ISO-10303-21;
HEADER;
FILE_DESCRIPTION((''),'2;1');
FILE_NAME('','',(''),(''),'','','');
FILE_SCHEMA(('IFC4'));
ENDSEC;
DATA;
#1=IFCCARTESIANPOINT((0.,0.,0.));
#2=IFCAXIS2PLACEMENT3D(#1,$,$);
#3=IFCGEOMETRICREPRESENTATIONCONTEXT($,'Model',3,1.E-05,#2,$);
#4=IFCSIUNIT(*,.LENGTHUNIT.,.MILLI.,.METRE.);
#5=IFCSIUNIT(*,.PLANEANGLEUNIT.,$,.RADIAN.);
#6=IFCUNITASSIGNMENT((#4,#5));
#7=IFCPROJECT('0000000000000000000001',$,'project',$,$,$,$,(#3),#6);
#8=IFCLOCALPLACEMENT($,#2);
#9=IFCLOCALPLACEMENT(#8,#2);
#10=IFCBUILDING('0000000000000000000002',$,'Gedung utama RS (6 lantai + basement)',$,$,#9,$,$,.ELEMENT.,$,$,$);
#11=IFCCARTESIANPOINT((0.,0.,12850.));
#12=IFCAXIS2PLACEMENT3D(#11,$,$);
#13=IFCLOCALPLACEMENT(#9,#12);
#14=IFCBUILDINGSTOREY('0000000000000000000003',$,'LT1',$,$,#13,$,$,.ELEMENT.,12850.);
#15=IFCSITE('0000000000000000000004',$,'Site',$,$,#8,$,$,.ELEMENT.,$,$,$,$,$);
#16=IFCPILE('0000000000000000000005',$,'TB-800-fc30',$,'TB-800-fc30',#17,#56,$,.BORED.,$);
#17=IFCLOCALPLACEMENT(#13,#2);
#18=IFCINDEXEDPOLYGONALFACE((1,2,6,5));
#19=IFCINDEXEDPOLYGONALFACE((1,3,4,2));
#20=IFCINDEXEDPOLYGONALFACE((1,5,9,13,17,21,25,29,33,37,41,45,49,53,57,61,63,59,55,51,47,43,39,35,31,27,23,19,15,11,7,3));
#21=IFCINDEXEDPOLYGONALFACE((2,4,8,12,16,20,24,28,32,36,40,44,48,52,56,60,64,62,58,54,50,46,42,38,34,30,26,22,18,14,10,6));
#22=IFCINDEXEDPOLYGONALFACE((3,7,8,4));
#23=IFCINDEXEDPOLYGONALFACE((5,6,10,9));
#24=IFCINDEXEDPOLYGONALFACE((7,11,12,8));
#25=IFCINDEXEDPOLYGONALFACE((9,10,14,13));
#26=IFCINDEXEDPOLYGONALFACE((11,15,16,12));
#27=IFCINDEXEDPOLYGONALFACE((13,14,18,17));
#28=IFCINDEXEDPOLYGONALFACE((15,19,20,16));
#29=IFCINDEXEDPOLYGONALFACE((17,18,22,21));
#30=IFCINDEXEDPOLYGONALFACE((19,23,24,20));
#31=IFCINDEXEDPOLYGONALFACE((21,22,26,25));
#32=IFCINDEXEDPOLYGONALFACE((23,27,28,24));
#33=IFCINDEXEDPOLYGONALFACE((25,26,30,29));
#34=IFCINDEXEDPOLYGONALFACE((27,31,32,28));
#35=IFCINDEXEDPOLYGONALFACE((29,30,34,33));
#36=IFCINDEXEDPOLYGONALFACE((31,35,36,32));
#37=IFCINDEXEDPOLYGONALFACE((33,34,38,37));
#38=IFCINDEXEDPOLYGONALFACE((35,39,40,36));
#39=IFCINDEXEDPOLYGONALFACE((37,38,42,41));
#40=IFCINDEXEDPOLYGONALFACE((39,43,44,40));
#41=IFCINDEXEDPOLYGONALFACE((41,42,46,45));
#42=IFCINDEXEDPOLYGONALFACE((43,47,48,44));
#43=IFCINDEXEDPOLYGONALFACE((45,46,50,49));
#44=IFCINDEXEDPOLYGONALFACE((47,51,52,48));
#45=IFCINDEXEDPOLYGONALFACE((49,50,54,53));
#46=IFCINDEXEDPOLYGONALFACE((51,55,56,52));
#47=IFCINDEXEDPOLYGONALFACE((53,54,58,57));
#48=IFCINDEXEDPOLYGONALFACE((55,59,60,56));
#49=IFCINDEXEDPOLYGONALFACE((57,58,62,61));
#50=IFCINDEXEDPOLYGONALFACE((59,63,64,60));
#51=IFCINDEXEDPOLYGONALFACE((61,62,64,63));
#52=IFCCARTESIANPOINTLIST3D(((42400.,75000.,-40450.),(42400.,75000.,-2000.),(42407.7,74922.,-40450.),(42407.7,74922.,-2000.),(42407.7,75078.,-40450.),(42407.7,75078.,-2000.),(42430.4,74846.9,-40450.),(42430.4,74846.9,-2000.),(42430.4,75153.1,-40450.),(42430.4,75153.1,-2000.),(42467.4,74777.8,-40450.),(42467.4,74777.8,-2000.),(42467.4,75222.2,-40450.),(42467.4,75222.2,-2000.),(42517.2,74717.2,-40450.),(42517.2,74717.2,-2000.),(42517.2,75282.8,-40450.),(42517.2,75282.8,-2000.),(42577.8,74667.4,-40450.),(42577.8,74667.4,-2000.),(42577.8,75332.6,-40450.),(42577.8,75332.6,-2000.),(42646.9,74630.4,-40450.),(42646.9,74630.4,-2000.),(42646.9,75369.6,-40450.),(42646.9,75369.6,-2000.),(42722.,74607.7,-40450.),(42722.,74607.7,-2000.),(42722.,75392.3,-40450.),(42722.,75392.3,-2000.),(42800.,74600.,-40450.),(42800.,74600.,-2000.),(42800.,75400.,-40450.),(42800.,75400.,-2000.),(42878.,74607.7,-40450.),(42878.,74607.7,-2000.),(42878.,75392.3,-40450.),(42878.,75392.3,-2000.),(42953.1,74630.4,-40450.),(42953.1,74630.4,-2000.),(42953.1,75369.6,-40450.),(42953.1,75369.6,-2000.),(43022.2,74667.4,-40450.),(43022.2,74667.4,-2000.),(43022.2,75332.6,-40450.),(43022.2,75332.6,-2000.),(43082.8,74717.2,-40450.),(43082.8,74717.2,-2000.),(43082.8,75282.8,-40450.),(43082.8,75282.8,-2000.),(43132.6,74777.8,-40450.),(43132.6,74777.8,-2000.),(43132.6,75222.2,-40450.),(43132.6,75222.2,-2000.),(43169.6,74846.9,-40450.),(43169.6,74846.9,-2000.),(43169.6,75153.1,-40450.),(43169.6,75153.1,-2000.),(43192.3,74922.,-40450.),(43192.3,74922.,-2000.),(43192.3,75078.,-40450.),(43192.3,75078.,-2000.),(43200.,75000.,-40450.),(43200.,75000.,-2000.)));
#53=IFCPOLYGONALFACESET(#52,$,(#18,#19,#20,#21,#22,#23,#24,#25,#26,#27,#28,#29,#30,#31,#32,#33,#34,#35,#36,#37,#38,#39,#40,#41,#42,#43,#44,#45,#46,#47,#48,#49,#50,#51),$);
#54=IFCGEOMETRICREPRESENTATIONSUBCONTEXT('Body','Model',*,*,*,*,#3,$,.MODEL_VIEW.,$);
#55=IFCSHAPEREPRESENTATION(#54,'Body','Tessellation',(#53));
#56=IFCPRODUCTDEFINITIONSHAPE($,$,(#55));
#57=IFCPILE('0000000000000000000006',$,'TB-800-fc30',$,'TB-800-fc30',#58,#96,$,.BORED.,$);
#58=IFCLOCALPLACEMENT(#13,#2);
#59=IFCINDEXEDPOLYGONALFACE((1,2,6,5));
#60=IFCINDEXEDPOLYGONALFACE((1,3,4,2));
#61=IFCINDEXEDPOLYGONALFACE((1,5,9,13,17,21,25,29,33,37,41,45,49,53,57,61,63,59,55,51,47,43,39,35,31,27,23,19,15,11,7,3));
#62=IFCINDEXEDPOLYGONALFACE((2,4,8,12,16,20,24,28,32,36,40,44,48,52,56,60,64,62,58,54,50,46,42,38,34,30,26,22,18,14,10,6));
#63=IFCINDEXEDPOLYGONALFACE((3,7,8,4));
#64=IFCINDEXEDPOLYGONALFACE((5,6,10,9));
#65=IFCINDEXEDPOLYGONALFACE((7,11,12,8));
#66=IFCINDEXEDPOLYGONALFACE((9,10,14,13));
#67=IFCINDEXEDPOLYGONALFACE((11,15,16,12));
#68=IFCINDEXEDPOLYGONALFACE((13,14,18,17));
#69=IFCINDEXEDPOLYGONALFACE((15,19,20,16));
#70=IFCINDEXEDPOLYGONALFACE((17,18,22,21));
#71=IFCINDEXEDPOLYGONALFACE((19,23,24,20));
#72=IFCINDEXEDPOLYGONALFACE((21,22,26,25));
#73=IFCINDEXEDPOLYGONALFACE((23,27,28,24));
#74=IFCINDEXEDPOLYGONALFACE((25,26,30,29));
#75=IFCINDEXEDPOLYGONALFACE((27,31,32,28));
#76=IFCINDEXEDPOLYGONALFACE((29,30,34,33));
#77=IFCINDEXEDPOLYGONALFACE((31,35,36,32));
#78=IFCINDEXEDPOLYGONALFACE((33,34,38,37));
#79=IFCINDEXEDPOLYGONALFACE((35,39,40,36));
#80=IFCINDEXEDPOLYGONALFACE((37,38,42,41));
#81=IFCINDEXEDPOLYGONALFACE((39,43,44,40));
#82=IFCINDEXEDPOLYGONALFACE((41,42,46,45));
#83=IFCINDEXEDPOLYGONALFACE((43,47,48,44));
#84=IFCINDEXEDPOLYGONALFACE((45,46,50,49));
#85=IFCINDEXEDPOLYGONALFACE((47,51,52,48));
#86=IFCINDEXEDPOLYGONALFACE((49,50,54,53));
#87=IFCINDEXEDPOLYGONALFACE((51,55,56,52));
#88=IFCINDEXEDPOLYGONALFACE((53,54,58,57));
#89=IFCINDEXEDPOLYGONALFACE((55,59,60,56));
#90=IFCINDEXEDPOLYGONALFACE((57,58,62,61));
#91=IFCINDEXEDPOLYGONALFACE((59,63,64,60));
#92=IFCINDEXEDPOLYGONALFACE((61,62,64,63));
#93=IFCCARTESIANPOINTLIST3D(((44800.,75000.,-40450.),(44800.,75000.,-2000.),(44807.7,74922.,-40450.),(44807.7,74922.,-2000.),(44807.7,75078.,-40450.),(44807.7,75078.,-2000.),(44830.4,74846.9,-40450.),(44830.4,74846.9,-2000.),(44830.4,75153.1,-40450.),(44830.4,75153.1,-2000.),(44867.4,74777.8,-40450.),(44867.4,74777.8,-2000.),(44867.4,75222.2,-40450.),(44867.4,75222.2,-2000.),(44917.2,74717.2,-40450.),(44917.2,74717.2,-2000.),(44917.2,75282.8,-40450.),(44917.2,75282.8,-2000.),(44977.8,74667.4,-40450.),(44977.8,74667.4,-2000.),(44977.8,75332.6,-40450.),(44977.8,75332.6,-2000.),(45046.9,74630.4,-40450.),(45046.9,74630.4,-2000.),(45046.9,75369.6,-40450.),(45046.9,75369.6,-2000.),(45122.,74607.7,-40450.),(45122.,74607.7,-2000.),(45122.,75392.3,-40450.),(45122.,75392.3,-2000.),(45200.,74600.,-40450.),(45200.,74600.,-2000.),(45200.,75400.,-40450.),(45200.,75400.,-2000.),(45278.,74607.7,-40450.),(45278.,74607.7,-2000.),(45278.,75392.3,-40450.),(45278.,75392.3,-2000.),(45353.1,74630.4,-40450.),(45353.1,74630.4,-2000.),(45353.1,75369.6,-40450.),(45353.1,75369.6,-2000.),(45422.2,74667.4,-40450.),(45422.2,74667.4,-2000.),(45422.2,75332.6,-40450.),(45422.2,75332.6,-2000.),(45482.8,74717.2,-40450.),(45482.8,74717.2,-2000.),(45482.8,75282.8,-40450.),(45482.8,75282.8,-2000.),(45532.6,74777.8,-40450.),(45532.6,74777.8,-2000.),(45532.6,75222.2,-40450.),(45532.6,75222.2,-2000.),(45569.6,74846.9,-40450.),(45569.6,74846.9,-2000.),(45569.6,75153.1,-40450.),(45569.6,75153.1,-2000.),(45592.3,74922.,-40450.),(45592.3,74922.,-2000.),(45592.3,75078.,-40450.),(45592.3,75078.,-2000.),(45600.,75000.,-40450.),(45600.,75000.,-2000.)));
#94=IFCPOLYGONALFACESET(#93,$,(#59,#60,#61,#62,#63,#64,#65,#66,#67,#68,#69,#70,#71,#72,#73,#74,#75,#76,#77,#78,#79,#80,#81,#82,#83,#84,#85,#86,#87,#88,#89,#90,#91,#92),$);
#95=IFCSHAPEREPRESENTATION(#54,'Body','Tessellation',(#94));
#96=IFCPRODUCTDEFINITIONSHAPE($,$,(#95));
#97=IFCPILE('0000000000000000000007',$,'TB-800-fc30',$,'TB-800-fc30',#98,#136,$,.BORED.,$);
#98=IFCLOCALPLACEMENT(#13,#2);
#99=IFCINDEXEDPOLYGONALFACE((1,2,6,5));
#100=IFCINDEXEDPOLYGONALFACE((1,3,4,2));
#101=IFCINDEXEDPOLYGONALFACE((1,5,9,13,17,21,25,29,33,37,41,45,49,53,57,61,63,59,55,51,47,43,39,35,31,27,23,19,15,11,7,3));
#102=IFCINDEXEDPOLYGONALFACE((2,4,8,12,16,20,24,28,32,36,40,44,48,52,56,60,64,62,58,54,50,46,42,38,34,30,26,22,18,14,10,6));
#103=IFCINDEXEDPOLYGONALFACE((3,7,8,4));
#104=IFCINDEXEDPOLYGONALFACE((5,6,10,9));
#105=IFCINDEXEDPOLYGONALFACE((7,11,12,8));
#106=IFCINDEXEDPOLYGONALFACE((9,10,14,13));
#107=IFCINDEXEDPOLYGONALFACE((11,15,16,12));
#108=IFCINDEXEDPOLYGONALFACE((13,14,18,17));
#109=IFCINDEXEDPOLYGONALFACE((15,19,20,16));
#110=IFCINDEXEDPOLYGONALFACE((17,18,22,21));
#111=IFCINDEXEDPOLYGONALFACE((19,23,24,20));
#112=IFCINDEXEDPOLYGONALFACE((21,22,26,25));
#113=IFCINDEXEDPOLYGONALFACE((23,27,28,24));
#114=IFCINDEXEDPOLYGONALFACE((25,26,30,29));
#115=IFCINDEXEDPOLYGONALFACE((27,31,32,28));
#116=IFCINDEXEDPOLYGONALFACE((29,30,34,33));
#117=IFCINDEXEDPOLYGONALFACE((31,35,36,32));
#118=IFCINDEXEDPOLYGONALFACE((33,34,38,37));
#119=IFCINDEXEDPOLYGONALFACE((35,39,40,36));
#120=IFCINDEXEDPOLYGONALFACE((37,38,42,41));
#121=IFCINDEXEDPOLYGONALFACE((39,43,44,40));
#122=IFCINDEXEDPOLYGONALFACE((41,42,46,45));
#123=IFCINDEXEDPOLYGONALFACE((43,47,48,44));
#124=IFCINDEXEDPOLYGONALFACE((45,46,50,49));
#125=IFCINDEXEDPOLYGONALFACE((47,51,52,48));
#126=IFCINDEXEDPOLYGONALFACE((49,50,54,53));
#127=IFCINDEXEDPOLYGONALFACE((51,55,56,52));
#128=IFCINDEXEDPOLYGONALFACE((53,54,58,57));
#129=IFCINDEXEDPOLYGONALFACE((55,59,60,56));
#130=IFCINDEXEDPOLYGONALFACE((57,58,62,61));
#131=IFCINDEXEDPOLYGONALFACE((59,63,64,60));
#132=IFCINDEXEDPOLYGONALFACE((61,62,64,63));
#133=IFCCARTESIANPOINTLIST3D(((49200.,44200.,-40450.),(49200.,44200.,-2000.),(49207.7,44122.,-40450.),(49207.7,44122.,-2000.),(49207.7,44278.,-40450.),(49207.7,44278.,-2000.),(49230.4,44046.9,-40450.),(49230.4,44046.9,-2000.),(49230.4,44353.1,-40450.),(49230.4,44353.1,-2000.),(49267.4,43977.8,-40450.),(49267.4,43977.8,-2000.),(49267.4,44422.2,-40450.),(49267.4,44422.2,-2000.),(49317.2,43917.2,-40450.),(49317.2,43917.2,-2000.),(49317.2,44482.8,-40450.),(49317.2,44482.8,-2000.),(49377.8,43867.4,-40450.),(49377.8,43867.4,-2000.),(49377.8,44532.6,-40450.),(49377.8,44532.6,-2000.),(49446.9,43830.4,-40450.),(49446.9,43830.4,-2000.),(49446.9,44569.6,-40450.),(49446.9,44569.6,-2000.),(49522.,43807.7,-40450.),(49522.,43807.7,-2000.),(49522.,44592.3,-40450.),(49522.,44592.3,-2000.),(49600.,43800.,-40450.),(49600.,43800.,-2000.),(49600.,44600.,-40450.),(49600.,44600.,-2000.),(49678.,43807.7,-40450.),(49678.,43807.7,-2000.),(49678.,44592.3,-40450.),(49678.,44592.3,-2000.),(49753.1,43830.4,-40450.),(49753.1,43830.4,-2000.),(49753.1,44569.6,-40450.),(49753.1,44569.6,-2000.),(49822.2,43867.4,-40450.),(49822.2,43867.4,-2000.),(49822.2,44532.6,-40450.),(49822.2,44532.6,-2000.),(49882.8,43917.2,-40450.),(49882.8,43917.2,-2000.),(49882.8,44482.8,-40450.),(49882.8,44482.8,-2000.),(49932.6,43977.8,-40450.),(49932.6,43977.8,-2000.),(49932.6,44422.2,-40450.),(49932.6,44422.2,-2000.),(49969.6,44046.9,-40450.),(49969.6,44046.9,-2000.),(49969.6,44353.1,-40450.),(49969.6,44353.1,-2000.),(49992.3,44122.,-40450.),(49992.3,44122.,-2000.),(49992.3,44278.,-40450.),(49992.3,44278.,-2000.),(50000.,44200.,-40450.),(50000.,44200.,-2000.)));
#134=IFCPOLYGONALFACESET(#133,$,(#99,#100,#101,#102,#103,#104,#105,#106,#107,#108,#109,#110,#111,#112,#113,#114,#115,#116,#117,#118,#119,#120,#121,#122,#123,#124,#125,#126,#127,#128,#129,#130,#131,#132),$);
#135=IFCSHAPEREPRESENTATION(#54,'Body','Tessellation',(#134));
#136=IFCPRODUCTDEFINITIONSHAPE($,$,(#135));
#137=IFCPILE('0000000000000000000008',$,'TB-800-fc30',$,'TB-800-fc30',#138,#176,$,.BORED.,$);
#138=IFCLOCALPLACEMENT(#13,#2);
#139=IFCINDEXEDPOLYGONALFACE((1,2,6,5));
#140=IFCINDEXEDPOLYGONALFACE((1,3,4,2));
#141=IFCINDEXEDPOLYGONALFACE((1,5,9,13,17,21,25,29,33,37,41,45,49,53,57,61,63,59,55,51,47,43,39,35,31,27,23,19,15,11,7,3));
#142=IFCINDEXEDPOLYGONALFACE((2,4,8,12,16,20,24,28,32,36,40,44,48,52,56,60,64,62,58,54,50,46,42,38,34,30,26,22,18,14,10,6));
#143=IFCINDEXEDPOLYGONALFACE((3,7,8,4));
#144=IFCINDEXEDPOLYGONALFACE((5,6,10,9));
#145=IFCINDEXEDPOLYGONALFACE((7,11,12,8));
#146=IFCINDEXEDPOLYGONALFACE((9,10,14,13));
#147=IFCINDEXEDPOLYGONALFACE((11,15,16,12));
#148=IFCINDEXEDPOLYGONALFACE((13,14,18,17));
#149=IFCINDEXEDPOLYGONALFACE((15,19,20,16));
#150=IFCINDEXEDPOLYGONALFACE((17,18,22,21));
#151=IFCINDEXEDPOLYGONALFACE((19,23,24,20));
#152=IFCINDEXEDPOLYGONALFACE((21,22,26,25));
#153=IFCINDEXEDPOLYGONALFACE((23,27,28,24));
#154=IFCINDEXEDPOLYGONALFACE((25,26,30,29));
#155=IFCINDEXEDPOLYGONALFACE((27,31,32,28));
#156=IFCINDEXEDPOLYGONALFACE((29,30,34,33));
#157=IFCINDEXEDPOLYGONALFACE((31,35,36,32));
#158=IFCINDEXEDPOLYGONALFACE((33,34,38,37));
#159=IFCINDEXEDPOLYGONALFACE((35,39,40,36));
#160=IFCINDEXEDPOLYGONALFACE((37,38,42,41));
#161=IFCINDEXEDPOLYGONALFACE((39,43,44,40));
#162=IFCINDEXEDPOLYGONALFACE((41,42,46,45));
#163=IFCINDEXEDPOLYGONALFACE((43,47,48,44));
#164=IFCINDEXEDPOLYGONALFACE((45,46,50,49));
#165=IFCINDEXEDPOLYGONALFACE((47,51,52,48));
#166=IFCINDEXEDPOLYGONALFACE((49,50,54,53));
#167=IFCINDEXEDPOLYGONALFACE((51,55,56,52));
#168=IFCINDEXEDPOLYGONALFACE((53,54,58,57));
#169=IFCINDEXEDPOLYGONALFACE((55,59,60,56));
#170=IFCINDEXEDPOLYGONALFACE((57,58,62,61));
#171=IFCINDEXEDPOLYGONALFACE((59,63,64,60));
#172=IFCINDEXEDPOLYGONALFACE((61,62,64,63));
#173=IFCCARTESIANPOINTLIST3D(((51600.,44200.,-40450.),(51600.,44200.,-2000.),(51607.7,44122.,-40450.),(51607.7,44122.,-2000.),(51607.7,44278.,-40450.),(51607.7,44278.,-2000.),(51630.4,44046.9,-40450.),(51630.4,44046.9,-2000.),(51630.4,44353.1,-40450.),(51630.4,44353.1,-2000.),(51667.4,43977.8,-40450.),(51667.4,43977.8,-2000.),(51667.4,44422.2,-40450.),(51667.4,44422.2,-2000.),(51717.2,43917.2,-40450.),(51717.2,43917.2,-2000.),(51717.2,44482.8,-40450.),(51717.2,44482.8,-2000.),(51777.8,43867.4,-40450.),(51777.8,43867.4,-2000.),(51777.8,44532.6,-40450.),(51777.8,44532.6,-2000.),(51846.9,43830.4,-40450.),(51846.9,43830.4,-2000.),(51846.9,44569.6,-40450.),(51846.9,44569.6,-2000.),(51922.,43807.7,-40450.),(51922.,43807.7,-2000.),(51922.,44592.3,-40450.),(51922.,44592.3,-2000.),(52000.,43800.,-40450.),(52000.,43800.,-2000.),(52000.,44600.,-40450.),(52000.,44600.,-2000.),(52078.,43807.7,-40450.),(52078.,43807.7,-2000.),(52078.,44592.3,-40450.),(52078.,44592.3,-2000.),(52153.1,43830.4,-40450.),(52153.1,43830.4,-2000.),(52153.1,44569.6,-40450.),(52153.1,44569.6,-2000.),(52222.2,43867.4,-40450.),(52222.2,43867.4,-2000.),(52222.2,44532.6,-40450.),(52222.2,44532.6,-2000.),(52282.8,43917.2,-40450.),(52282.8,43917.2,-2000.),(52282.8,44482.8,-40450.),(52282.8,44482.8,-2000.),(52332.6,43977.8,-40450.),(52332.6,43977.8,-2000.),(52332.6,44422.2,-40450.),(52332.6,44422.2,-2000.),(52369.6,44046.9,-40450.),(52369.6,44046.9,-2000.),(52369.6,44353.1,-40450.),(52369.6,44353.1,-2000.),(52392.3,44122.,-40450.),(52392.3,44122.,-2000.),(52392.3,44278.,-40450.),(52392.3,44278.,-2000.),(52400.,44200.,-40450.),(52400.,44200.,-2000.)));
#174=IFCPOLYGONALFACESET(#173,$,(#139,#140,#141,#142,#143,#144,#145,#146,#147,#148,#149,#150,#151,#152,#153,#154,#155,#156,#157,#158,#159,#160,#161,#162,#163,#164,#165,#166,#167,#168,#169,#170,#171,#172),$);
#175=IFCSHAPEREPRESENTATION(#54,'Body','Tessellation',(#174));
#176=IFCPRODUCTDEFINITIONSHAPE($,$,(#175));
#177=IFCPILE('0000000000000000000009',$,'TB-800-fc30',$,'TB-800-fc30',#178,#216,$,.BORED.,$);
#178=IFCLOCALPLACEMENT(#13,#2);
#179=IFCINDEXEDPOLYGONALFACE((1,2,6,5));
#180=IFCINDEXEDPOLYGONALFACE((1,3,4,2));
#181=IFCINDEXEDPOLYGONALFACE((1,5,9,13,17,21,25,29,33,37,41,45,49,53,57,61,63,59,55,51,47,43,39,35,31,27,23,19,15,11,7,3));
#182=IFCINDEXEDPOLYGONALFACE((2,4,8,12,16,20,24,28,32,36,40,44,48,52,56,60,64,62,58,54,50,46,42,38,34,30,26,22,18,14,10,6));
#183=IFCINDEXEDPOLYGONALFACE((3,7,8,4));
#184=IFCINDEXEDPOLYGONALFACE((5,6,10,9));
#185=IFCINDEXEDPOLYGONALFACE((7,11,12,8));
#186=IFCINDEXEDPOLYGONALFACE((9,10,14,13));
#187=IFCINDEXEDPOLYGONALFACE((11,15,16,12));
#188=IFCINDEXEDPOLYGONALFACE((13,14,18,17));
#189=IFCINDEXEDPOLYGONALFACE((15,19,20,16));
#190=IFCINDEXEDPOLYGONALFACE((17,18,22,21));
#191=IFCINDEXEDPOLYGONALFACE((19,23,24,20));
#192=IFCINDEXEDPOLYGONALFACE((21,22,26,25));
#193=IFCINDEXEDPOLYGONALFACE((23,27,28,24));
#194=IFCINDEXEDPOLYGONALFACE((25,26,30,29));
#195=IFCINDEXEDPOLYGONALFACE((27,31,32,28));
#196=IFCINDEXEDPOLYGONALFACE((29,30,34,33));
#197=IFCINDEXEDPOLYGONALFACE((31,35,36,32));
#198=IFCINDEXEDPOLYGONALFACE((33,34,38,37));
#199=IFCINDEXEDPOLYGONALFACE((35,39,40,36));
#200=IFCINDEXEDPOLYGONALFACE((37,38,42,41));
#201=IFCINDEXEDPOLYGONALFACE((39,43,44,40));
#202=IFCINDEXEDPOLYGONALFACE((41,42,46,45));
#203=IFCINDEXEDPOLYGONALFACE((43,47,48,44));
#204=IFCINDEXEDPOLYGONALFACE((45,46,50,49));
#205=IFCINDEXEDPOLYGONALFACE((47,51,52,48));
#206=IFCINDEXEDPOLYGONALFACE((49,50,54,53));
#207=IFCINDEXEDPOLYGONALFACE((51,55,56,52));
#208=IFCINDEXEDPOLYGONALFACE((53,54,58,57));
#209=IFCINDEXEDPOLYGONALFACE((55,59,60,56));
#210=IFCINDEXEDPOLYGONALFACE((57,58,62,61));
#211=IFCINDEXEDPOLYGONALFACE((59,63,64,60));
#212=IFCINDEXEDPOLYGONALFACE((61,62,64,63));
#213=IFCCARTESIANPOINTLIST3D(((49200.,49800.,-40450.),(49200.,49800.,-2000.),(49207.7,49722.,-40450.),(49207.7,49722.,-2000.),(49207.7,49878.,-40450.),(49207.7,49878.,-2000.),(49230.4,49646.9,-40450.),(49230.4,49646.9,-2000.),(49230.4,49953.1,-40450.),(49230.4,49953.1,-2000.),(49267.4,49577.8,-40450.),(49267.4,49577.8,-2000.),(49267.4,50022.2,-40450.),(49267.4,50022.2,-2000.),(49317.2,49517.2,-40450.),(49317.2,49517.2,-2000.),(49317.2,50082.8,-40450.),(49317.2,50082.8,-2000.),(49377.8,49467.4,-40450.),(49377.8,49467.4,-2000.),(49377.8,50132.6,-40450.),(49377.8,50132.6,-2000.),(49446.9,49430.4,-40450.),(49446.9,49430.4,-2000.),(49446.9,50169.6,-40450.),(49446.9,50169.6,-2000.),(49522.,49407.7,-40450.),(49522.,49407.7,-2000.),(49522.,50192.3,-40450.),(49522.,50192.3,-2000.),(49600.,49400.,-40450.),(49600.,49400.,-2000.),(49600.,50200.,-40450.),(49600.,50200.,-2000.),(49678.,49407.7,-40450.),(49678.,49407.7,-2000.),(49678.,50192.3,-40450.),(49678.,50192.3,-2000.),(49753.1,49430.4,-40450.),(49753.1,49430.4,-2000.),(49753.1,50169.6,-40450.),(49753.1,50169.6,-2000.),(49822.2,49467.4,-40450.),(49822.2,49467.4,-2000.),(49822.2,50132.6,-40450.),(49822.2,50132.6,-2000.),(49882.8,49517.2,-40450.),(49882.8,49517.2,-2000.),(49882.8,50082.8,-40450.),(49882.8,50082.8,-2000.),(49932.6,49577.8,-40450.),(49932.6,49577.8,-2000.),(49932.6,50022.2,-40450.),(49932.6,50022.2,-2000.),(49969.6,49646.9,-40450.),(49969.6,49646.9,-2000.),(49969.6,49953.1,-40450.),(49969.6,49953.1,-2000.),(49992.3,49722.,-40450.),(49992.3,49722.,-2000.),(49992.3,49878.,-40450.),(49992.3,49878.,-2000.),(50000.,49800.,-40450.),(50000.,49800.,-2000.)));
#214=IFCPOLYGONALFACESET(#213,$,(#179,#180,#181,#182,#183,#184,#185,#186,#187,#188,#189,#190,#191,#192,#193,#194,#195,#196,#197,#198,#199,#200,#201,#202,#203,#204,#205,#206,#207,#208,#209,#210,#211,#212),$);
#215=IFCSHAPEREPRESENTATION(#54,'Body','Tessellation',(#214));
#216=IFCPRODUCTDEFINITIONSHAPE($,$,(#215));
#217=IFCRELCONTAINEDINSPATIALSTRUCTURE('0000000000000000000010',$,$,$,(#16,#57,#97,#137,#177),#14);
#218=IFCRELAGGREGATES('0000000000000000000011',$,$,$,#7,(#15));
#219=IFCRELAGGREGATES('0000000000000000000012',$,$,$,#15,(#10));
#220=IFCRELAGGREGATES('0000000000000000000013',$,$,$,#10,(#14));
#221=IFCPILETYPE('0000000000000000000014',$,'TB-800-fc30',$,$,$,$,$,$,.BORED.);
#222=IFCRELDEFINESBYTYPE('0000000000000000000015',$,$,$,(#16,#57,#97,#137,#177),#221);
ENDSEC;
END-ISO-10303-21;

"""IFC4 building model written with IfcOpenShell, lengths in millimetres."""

from ifc_helpers import new_model, si_unit, frame, origin, origin_2d, place, context, subcontext, project, spatial, circle, extrude, material_profile, profile_set, profile_usage, type_object, element, save


model = new_model("IFC4")

# Units and contexts
model_context = context("Model", 3, precision=1e-05, world=origin())
body_context = subcontext(model_context, "Body", "Model", "MODEL_VIEW")
ifc_project = project(units=[si_unit("LENGTHUNIT", "METRE", prefix="MILLI"), si_unit("PLANEANGLEUNIT", "RADIAN")], contexts=[model_context])

# Site, building, storey
site_placement = place(None, origin())
site = spatial("IfcSite", under=ifc_project, at=site_placement, Name="Site", CompositionType="ELEMENT")
building_placement = place(site_placement, origin())
building = spatial("IfcBuilding", under=site, at=building_placement, Name="Gedung utama RS (6 lantai + basement)", CompositionType="ELEMENT")
storey_placement = place(building_placement, frame((0.0, 0.0, 12850.0)))
storey = spatial("IfcBuildingStorey", under=building, at=storey_placement, Name="LT1", CompositionType="ELEMENT", Elevation=12850.0)

# Piles
ifc_material_profile = material_profile(None, circle(Radius=400.0, at=origin_2d()), Name="TB-800-fc30")
ifc_profile_set = profile_set([ifc_material_profile], Name="TB-800-fc30")
ifc_profile_usage = profile_usage(ifc_profile_set, cardinal=5)
pile_type = type_object("IfcPileType", Name="TB-800-fc30", PredefinedType="BORED", material=ifc_profile_set)
for number, where, z_axis, x_axis, name in (
    (1, (42800.0, 75000.0, -40450.0), (0.0, 0.0, 1.0), (1.0, 0.0, 0.0), "TB-800-fc30"),
    (2, (45200.0, 75000.0, -40450.0), (0.0, 0.0, 1.0), (1.0, 0.0, 0.0), "TB-800-fc30"),
    (3, (49600.0, 44200.0, -40450.0), (0.0, 0.0, 1.0), (1.0, 0.0, 0.0), "TB-800-fc30"),
    (4, (52000.0, 44200.0, -40450.0), (0.0, 0.0, 1.0), (1.0, 0.0, 0.0), "TB-800-fc30"),
    (5, (49600.0, 49800.0, -40450.0), (0.0, 0.0, 1.0), (1.0, 0.0, 0.0), "TB-800-fc30"),
):
    element("IfcPile", number, at=place(storey_placement, frame(where, z_axis=z_axis, x_axis=x_axis)), inside=storey, type_object=pile_type, material=ifc_profile_usage, Name=name, ObjectType="TB-800-fc30", PredefinedType="BORED", context=body_context, shape_type="SweptSolid", body=[
        extrude(circle(Radius=400.0, at=origin_2d()), origin(), (0.0, 0.0, 1.0), 38450.0),
    ])

save(model, "model.ifc")
